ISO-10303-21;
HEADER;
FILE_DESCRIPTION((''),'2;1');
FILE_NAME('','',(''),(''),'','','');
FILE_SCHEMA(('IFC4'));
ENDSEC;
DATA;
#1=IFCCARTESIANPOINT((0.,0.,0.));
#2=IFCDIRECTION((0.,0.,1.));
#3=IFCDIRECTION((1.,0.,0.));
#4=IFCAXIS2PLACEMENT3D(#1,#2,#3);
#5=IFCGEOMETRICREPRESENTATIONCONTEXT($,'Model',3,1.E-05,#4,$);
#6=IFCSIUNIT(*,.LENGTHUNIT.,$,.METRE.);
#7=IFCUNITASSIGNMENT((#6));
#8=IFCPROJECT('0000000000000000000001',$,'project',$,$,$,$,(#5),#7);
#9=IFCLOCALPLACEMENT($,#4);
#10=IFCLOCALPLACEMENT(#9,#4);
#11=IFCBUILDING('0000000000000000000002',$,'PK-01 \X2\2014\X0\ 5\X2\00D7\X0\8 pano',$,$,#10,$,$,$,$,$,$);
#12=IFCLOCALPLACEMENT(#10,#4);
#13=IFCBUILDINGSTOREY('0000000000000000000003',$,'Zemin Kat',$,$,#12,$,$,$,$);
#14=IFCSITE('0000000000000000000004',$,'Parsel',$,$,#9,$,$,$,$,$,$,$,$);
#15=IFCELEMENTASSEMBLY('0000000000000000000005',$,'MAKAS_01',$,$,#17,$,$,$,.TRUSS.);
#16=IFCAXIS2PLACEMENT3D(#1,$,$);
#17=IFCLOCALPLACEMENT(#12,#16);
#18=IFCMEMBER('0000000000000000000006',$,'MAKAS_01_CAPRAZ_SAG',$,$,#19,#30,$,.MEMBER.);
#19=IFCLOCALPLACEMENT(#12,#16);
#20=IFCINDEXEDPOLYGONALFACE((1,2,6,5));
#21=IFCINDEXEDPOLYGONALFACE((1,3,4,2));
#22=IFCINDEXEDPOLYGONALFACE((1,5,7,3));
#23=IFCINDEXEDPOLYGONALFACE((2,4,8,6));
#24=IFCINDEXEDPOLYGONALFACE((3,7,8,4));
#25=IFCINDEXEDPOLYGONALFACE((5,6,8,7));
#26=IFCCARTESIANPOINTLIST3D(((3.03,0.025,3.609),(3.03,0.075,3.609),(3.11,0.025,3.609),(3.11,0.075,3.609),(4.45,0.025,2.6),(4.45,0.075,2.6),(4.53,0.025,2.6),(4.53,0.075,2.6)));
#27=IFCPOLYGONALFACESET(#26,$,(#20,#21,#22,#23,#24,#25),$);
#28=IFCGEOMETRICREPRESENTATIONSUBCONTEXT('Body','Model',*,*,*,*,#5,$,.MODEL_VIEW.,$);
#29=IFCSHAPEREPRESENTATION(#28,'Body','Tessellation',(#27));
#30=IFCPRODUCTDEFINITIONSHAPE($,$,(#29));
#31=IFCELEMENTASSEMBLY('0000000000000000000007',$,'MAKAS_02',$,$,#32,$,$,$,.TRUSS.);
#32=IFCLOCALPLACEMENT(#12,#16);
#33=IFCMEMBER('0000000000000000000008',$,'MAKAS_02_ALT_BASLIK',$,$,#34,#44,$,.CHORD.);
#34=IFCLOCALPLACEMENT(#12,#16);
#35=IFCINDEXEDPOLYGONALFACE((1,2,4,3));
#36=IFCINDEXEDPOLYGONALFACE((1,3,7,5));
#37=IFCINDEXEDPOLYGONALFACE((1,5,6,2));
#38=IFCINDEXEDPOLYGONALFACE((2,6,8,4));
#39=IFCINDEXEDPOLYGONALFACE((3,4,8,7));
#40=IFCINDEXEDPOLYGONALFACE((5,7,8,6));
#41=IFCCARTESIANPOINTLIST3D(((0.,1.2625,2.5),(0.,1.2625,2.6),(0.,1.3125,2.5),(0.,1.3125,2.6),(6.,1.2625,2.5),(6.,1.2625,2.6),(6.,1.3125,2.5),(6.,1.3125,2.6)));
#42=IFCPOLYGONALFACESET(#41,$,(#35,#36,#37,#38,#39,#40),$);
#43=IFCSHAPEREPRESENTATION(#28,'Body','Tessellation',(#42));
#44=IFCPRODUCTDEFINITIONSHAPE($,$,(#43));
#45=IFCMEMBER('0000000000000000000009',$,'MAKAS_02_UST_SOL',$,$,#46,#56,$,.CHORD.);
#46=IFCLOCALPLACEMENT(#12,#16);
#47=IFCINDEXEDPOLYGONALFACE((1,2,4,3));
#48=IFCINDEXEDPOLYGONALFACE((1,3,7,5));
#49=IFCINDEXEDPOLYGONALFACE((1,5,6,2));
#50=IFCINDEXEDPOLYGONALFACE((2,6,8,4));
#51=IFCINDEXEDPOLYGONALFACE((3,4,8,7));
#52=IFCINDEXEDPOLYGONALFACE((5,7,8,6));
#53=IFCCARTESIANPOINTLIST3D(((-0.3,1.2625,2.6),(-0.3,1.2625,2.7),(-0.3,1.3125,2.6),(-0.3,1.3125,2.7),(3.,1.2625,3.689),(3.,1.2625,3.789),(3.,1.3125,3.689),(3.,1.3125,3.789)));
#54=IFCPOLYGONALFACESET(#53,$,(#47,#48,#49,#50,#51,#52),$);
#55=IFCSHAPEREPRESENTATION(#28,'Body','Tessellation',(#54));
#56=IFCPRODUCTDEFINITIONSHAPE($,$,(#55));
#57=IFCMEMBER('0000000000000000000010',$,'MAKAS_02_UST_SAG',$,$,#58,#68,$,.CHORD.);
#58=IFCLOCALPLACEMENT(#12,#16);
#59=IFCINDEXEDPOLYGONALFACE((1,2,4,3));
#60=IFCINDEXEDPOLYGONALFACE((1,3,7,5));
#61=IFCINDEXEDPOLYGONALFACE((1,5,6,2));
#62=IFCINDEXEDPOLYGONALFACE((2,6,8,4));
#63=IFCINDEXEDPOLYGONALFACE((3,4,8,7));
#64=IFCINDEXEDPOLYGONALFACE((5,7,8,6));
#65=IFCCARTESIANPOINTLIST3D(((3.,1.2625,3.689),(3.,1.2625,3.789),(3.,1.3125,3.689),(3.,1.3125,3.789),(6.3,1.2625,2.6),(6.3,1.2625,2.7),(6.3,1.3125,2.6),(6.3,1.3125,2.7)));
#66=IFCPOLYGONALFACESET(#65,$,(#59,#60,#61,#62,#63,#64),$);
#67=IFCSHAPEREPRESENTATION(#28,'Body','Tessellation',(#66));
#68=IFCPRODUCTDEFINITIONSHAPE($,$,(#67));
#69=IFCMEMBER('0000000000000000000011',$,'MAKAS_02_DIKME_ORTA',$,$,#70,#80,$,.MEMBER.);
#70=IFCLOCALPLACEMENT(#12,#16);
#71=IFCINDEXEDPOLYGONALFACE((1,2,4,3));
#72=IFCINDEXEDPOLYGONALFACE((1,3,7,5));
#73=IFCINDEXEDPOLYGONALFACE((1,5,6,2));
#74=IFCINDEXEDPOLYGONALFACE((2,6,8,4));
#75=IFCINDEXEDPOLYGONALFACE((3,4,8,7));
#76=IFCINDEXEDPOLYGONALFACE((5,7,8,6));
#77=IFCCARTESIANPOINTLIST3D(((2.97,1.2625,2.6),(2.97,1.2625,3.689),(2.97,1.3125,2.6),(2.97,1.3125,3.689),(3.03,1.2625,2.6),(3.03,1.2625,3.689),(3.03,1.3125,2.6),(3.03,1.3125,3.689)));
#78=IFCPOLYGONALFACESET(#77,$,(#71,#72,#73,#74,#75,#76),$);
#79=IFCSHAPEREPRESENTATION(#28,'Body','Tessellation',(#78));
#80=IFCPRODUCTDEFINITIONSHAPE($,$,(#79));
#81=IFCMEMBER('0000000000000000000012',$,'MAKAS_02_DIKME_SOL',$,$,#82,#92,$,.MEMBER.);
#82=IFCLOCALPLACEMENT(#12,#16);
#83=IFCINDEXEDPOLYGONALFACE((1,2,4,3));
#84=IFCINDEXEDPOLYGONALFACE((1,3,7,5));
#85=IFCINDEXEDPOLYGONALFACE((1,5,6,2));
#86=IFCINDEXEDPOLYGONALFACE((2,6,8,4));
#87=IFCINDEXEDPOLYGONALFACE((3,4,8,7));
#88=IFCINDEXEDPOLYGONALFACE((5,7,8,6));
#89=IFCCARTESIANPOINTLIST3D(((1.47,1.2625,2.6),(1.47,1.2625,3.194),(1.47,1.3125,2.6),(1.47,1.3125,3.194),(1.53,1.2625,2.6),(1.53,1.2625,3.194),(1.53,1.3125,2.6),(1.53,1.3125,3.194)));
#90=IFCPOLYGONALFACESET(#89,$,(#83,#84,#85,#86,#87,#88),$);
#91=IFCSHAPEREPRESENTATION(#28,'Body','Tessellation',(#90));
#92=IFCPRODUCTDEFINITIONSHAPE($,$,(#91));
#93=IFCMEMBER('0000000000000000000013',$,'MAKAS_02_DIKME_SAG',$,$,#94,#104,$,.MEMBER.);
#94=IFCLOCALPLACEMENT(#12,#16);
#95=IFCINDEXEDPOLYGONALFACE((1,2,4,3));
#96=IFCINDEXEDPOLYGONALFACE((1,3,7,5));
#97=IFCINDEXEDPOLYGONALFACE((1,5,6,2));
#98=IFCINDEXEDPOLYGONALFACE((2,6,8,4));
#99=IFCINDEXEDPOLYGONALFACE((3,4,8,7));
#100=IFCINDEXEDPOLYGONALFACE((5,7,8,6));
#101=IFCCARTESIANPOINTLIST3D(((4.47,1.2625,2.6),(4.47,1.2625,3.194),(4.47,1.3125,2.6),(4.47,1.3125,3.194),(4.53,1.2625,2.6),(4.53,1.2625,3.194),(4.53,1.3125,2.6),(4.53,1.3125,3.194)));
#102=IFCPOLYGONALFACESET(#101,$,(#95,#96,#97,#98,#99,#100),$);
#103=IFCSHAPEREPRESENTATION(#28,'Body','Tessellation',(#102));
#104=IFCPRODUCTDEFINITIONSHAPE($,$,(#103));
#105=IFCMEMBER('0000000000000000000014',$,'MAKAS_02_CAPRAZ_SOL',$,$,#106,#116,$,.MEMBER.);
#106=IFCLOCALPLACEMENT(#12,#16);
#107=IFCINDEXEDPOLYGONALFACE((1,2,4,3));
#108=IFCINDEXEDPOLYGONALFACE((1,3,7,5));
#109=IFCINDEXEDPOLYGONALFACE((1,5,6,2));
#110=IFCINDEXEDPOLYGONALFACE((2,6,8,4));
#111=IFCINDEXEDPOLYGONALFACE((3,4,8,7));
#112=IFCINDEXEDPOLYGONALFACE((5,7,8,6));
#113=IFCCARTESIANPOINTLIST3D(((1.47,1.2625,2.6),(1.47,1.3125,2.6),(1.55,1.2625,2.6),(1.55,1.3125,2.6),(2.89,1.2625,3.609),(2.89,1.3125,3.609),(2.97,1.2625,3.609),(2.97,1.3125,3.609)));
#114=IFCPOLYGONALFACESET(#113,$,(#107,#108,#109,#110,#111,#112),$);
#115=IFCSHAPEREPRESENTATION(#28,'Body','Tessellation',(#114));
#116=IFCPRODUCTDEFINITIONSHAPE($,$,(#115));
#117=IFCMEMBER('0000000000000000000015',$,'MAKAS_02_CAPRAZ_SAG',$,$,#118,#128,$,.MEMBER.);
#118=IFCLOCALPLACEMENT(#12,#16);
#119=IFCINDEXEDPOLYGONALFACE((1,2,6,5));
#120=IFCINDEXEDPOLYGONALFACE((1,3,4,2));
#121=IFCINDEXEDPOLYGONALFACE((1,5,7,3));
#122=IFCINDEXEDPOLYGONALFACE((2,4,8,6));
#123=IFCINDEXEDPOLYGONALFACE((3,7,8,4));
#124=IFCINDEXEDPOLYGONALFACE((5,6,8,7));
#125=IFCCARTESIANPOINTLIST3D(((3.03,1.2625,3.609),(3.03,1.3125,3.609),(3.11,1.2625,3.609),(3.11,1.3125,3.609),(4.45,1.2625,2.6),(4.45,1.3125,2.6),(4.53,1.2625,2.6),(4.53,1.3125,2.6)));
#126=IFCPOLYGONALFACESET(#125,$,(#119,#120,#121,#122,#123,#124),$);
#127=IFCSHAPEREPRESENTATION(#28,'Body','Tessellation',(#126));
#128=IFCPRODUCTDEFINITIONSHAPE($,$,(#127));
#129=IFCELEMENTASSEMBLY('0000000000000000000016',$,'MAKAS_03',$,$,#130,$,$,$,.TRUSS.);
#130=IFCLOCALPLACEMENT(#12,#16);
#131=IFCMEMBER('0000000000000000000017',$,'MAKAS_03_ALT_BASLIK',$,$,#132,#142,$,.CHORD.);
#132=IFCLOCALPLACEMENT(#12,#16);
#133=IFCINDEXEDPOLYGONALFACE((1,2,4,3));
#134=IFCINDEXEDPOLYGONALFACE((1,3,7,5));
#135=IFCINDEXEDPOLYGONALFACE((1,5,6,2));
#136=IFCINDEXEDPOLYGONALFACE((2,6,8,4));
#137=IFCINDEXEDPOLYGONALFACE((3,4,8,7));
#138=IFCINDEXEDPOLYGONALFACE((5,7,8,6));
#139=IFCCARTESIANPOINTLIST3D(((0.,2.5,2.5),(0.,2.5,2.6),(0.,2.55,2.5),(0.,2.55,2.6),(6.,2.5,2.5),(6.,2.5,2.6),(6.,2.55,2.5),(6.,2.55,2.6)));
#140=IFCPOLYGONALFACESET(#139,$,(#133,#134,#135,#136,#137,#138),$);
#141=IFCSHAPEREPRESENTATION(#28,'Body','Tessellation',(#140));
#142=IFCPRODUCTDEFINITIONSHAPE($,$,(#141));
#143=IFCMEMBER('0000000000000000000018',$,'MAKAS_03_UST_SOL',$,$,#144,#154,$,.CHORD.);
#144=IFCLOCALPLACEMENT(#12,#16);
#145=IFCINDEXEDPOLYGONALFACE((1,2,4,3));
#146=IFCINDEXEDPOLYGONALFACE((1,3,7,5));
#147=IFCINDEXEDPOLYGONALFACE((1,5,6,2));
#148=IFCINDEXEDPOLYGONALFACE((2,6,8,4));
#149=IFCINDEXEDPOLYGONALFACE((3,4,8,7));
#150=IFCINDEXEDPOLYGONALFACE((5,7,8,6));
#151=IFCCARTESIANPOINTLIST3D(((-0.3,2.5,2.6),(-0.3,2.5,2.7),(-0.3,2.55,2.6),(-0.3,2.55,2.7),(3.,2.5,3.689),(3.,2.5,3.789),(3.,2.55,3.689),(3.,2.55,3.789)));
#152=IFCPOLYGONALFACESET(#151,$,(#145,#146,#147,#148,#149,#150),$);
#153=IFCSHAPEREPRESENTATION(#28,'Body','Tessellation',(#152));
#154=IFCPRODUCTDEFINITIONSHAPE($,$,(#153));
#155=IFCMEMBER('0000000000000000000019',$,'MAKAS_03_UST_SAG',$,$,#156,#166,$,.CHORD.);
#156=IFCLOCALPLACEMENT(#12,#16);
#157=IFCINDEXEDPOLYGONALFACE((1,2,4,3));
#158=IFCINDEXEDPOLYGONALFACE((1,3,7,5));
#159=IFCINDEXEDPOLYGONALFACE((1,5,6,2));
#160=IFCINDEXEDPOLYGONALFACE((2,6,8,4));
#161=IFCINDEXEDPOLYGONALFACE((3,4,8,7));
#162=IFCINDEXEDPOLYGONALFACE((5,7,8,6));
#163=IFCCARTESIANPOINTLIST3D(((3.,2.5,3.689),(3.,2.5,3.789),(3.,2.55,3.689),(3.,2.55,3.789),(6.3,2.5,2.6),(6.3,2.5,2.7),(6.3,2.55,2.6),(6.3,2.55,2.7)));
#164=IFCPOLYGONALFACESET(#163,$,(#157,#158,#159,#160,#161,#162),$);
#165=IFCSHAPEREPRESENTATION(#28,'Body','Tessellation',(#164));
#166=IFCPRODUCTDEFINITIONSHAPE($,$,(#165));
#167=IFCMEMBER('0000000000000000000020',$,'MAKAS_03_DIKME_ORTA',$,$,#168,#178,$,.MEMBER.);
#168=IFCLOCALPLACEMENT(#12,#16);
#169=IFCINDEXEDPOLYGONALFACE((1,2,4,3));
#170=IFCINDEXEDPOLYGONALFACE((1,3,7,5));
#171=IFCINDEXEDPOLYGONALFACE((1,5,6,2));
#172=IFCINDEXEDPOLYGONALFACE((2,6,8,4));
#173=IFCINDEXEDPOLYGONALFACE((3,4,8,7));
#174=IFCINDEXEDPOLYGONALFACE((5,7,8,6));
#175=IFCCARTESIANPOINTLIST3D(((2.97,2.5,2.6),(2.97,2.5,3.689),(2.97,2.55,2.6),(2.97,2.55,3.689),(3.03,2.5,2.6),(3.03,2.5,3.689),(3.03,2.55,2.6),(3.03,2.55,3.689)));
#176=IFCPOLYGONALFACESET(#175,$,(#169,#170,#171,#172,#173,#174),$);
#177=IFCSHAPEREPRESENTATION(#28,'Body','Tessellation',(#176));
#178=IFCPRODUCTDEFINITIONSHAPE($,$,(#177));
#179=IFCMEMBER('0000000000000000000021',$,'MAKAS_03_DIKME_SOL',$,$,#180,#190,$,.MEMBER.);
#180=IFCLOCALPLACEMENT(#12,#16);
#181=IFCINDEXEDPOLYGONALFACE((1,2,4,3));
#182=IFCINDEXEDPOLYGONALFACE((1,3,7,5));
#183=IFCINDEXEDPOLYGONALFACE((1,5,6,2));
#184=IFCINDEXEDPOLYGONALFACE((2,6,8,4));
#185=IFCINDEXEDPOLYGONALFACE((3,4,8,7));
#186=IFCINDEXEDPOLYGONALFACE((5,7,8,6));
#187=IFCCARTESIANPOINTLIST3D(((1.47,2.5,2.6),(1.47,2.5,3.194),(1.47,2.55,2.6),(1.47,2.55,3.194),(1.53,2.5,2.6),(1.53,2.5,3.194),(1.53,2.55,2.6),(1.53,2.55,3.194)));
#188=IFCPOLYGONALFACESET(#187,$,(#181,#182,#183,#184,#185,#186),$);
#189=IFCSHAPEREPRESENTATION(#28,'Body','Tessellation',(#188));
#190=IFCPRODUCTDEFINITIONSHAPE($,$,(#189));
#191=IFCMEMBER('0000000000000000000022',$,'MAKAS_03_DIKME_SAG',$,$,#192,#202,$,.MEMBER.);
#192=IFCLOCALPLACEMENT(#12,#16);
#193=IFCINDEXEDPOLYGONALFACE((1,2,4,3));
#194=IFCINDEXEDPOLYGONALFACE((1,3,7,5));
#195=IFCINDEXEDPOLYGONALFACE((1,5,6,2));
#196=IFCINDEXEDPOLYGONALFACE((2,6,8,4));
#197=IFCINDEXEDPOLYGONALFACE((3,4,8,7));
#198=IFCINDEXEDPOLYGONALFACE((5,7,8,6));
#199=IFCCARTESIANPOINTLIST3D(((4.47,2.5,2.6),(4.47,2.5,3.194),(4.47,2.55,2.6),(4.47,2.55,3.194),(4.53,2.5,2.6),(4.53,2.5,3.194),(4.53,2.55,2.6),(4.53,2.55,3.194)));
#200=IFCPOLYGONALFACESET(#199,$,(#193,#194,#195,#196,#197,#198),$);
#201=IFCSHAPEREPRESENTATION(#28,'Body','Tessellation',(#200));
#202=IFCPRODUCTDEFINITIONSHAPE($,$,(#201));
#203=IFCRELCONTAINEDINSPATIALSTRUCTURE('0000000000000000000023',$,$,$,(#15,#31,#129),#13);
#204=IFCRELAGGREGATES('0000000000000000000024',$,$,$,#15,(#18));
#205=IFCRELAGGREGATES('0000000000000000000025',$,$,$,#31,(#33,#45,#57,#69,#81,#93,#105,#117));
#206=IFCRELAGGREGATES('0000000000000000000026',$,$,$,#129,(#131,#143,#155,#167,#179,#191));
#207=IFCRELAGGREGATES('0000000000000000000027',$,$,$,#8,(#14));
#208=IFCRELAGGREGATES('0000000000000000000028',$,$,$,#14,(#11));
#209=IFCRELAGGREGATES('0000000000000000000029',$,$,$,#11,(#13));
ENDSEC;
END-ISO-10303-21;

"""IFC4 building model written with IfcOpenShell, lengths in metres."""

from ifc_helpers import new_model, si_unit, frame, origin_with_axes, place, context, subcontext, project, spatial, line, indexed_curve, outline, extrude, element, aggregate, save


model = new_model("IFC4")

# Units and contexts
model_context = context("Model", 3, precision=1e-05, world=origin_with_axes())
body_context = subcontext(model_context, "Body", "Model", "MODEL_VIEW")
ifc_project = project(units=[si_unit("LENGTHUNIT", "METRE")], contexts=[model_context])

# Site, building, storey
site_placement = place(None, origin_with_axes())
site = spatial("IfcSite", under=ifc_project, at=site_placement, Name="Parsel")
building_placement = place(site_placement, origin_with_axes())
building = spatial("IfcBuilding", under=site, at=building_placement, Name="PK-01 — 5×8 pano")
storey_placement = place(building_placement, origin_with_axes())
storey = spatial("IfcBuildingStorey", under=building, at=storey_placement, Name="Zemin Kat")

# Element assembly, member
assembly_1_placement = place(storey_placement, origin_with_axes())
assembly_1 = element("IfcElementAssembly", 1, at=assembly_1_placement, inside=storey, Name="MAKAS_01", PredefinedType="TRUSS")
member_1_placement = place(assembly_1_placement, origin_with_axes())
member_1 = element("IfcMember", 2, at=member_1_placement, Name="MAKAS_01_CAPRAZ_SAG", PredefinedType="MEMBER", context=body_context, shape_type="SweptSolid", body=[
    extrude(outline(indexed_curve([(4.45, 2.6), (4.53, 2.6), (3.11, 3.609), (3.03, 3.609)], segments=[line(1, 2, 3, 4, 1)])), frame((0.0, 0.075, 0.0), z_axis=(0.0, -1.0, 0.0), x_axis=(1.0, 0.0, 0.0)), (0.0, 0.0, 1.0), 0.05),
])
aggregate(assembly_1, [member_1])

# Element assemblies, members
assembly_2_placement = place(storey_placement, origin_with_axes())
assembly_2 = element("IfcElementAssembly", 3, at=assembly_2_placement, inside=storey, Name="MAKAS_02", PredefinedType="TRUSS")
member_2_placement = place(assembly_2_placement, origin_with_axes())
member_2 = element("IfcMember", 4, at=member_2_placement, Name="MAKAS_02_ALT_BASLIK", PredefinedType="CHORD", context=body_context, shape_type="SweptSolid", body=[
    extrude(outline(indexed_curve([(0.0, 2.5), (6.0, 2.5), (6.0, 2.6), (0.0, 2.6)], segments=[line(1, 2, 3, 4, 1)])), frame((0.0, 1.3125, 0.0), z_axis=(0.0, -1.0, 0.0), x_axis=(1.0, 0.0, 0.0)), (0.0, 0.0, 1.0), 0.05),
])
member_3_placement = place(assembly_2_placement, origin_with_axes())
member_3 = element("IfcMember", 5, at=member_3_placement, Name="MAKAS_02_UST_SOL", PredefinedType="CHORD", context=body_context, shape_type="SweptSolid", body=[
    extrude(outline(indexed_curve([(-0.3, 2.6), (3.0, 3.689), (3.0, 3.789), (-0.3, 2.7)], segments=[line(1, 2, 3, 4, 1)])), frame((0.0, 1.3125, 0.0), z_axis=(0.0, -1.0, 0.0), x_axis=(1.0, 0.0, 0.0)), (0.0, 0.0, 1.0), 0.05),
])
member_4_placement = place(assembly_2_placement, origin_with_axes())
member_4 = element("IfcMember", 6, at=member_4_placement, Name="MAKAS_02_UST_SAG", PredefinedType="CHORD", context=body_context, shape_type="SweptSolid", body=[
    extrude(outline(indexed_curve([(3.0, 3.689), (6.3, 2.6), (6.3, 2.7), (3.0, 3.789)], segments=[line(1, 2, 3, 4, 1)])), frame((0.0, 1.3125, 0.0), z_axis=(0.0, -1.0, 0.0), x_axis=(1.0, 0.0, 0.0)), (0.0, 0.0, 1.0), 0.05),
])
member_5_placement = place(assembly_2_placement, origin_with_axes())
member_5 = element("IfcMember", 7, at=member_5_placement, Name="MAKAS_02_DIKME_ORTA", PredefinedType="MEMBER", context=body_context, shape_type="SweptSolid", body=[
    extrude(outline(indexed_curve([(2.97, 2.6), (3.03, 2.6), (3.03, 3.689), (2.97, 3.689)], segments=[line(1, 2, 3, 4, 1)])), frame((0.0, 1.3125, 0.0), z_axis=(0.0, -1.0, 0.0), x_axis=(1.0, 0.0, 0.0)), (0.0, 0.0, 1.0), 0.05),
])
member_6_placement = place(assembly_2_placement, origin_with_axes())
member_6 = element("IfcMember", 8, at=member_6_placement, Name="MAKAS_02_DIKME_SOL", PredefinedType="MEMBER", context=body_context, shape_type="SweptSolid", body=[
    extrude(outline(indexed_curve([(1.47, 2.6), (1.53, 2.6), (1.53, 3.194), (1.47, 3.194)], segments=[line(1, 2, 3, 4, 1)])), frame((0.0, 1.3125, 0.0), z_axis=(0.0, -1.0, 0.0), x_axis=(1.0, 0.0, 0.0)), (0.0, 0.0, 1.0), 0.05),
])
member_7_placement = place(assembly_2_placement, origin_with_axes())
member_7 = element("IfcMember", 9, at=member_7_placement, Name="MAKAS_02_DIKME_SAG", PredefinedType="MEMBER", context=body_context, shape_type="SweptSolid", body=[
    extrude(outline(indexed_curve([(4.47, 2.6), (4.53, 2.6), (4.53, 3.194), (4.47, 3.194)], segments=[line(1, 2, 3, 4, 1)])), frame((0.0, 1.3125, 0.0), z_axis=(0.0, -1.0, 0.0), x_axis=(1.0, 0.0, 0.0)), (0.0, 0.0, 1.0), 0.05),
])
member_8_placement = place(assembly_2_placement, origin_with_axes())
member_8 = element("IfcMember", 10, at=member_8_placement, Name="MAKAS_02_CAPRAZ_SOL", PredefinedType="MEMBER", context=body_context, shape_type="SweptSolid", body=[
    extrude(outline(indexed_curve([(1.47, 2.6), (1.55, 2.6), (2.97, 3.609), (2.89, 3.609)], segments=[line(1, 2, 3, 4, 1)])), frame((0.0, 1.3125, 0.0), z_axis=(0.0, -1.0, 0.0), x_axis=(1.0, 0.0, 0.0)), (0.0, 0.0, 1.0), 0.05),
])
member_9_placement = place(assembly_2_placement, origin_with_axes())
member_9 = element("IfcMember", 11, at=member_9_placement, Name="MAKAS_02_CAPRAZ_SAG", PredefinedType="MEMBER", context=body_context, shape_type="SweptSolid", body=[
    extrude(outline(indexed_curve([(4.45, 2.6), (4.53, 2.6), (3.11, 3.609), (3.03, 3.609)], segments=[line(1, 2, 3, 4, 1)])), frame((0.0, 1.3125, 0.0), z_axis=(0.0, -1.0, 0.0), x_axis=(1.0, 0.0, 0.0)), (0.0, 0.0, 1.0), 0.05),
])
aggregate(assembly_2, [member_2, member_3, member_4, member_5, member_6, member_7, member_8, member_9])
assembly_3_placement = place(storey_placement, origin_with_axes())
assembly_3 = element("IfcElementAssembly", 12, at=assembly_3_placement, inside=storey, Name="MAKAS_03", PredefinedType="TRUSS")
member_10_placement = place(assembly_3_placement, origin_with_axes())
member_10 = element("IfcMember", 13, at=member_10_placement, Name="MAKAS_03_ALT_BASLIK", PredefinedType="CHORD", context=body_context, shape_type="SweptSolid", body=[
    extrude(outline(indexed_curve([(0.0, 2.5), (6.0, 2.5), (6.0, 2.6), (0.0, 2.6)], segments=[line(1, 2, 3, 4, 1)])), frame((0.0, 2.55, 0.0), z_axis=(0.0, -1.0, 0.0), x_axis=(1.0, 0.0, 0.0)), (0.0, 0.0, 1.0), 0.05),
])
member_11_placement = place(assembly_3_placement, origin_with_axes())
member_11 = element("IfcMember", 14, at=member_11_placement, Name="MAKAS_03_UST_SOL", PredefinedType="CHORD", context=body_context, shape_type="SweptSolid", body=[
    extrude(outline(indexed_curve([(-0.3, 2.6), (3.0, 3.689), (3.0, 3.789), (-0.3, 2.7)], segments=[line(1, 2, 3, 4, 1)])), frame((0.0, 2.55, 0.0), z_axis=(0.0, -1.0, 0.0), x_axis=(1.0, 0.0, 0.0)), (0.0, 0.0, 1.0), 0.05),
])
member_12_placement = place(assembly_3_placement, origin_with_axes())
member_12 = element("IfcMember", 15, at=member_12_placement, Name="MAKAS_03_UST_SAG", PredefinedType="CHORD", context=body_context, shape_type="SweptSolid", body=[
    extrude(outline(indexed_curve([(3.0, 3.689), (6.3, 2.6), (6.3, 2.7), (3.0, 3.789)], segments=[line(1, 2, 3, 4, 1)])), frame((0.0, 2.55, 0.0), z_axis=(0.0, -1.0, 0.0), x_axis=(1.0, 0.0, 0.0)), (0.0, 0.0, 1.0), 0.05),
])
member_13_placement = place(assembly_3_placement, origin_with_axes())
member_13 = element("IfcMember", 16, at=member_13_placement, Name="MAKAS_03_DIKME_ORTA", PredefinedType="MEMBER", context=body_context, shape_type="SweptSolid", body=[
    extrude(outline(indexed_curve([(2.97, 2.6), (3.03, 2.6), (3.03, 3.689), (2.97, 3.689)], segments=[line(1, 2, 3, 4, 1)])), frame((0.0, 2.55, 0.0), z_axis=(0.0, -1.0, 0.0), x_axis=(1.0, 0.0, 0.0)), (0.0, 0.0, 1.0), 0.05),
])
member_14_placement = place(assembly_3_placement, origin_with_axes())
member_14 = element("IfcMember", 17, at=member_14_placement, Name="MAKAS_03_DIKME_SOL", PredefinedType="MEMBER", context=body_context, shape_type="SweptSolid", body=[
    extrude(outline(indexed_curve([(1.47, 2.6), (1.53, 2.6), (1.53, 3.194), (1.47, 3.194)], segments=[line(1, 2, 3, 4, 1)])), frame((0.0, 2.55, 0.0), z_axis=(0.0, -1.0, 0.0), x_axis=(1.0, 0.0, 0.0)), (0.0, 0.0, 1.0), 0.05),
])
member_15_placement = place(assembly_3_placement, origin_with_axes())
member_15 = element("IfcMember", 18, at=member_15_placement, Name="MAKAS_03_DIKME_SAG", PredefinedType="MEMBER", context=body_context, shape_type="SweptSolid", body=[
    extrude(outline(indexed_curve([(4.47, 2.6), (4.53, 2.6), (4.53, 3.194), (4.47, 3.194)], segments=[line(1, 2, 3, 4, 1)])), frame((0.0, 2.55, 0.0), z_axis=(0.0, -1.0, 0.0), x_axis=(1.0, 0.0, 0.0)), (0.0, 0.0, 1.0), 0.05),
])
aggregate(assembly_3, [member_10, member_11, member_12, member_13, member_14, member_15])

save(model, "model.ifc")
